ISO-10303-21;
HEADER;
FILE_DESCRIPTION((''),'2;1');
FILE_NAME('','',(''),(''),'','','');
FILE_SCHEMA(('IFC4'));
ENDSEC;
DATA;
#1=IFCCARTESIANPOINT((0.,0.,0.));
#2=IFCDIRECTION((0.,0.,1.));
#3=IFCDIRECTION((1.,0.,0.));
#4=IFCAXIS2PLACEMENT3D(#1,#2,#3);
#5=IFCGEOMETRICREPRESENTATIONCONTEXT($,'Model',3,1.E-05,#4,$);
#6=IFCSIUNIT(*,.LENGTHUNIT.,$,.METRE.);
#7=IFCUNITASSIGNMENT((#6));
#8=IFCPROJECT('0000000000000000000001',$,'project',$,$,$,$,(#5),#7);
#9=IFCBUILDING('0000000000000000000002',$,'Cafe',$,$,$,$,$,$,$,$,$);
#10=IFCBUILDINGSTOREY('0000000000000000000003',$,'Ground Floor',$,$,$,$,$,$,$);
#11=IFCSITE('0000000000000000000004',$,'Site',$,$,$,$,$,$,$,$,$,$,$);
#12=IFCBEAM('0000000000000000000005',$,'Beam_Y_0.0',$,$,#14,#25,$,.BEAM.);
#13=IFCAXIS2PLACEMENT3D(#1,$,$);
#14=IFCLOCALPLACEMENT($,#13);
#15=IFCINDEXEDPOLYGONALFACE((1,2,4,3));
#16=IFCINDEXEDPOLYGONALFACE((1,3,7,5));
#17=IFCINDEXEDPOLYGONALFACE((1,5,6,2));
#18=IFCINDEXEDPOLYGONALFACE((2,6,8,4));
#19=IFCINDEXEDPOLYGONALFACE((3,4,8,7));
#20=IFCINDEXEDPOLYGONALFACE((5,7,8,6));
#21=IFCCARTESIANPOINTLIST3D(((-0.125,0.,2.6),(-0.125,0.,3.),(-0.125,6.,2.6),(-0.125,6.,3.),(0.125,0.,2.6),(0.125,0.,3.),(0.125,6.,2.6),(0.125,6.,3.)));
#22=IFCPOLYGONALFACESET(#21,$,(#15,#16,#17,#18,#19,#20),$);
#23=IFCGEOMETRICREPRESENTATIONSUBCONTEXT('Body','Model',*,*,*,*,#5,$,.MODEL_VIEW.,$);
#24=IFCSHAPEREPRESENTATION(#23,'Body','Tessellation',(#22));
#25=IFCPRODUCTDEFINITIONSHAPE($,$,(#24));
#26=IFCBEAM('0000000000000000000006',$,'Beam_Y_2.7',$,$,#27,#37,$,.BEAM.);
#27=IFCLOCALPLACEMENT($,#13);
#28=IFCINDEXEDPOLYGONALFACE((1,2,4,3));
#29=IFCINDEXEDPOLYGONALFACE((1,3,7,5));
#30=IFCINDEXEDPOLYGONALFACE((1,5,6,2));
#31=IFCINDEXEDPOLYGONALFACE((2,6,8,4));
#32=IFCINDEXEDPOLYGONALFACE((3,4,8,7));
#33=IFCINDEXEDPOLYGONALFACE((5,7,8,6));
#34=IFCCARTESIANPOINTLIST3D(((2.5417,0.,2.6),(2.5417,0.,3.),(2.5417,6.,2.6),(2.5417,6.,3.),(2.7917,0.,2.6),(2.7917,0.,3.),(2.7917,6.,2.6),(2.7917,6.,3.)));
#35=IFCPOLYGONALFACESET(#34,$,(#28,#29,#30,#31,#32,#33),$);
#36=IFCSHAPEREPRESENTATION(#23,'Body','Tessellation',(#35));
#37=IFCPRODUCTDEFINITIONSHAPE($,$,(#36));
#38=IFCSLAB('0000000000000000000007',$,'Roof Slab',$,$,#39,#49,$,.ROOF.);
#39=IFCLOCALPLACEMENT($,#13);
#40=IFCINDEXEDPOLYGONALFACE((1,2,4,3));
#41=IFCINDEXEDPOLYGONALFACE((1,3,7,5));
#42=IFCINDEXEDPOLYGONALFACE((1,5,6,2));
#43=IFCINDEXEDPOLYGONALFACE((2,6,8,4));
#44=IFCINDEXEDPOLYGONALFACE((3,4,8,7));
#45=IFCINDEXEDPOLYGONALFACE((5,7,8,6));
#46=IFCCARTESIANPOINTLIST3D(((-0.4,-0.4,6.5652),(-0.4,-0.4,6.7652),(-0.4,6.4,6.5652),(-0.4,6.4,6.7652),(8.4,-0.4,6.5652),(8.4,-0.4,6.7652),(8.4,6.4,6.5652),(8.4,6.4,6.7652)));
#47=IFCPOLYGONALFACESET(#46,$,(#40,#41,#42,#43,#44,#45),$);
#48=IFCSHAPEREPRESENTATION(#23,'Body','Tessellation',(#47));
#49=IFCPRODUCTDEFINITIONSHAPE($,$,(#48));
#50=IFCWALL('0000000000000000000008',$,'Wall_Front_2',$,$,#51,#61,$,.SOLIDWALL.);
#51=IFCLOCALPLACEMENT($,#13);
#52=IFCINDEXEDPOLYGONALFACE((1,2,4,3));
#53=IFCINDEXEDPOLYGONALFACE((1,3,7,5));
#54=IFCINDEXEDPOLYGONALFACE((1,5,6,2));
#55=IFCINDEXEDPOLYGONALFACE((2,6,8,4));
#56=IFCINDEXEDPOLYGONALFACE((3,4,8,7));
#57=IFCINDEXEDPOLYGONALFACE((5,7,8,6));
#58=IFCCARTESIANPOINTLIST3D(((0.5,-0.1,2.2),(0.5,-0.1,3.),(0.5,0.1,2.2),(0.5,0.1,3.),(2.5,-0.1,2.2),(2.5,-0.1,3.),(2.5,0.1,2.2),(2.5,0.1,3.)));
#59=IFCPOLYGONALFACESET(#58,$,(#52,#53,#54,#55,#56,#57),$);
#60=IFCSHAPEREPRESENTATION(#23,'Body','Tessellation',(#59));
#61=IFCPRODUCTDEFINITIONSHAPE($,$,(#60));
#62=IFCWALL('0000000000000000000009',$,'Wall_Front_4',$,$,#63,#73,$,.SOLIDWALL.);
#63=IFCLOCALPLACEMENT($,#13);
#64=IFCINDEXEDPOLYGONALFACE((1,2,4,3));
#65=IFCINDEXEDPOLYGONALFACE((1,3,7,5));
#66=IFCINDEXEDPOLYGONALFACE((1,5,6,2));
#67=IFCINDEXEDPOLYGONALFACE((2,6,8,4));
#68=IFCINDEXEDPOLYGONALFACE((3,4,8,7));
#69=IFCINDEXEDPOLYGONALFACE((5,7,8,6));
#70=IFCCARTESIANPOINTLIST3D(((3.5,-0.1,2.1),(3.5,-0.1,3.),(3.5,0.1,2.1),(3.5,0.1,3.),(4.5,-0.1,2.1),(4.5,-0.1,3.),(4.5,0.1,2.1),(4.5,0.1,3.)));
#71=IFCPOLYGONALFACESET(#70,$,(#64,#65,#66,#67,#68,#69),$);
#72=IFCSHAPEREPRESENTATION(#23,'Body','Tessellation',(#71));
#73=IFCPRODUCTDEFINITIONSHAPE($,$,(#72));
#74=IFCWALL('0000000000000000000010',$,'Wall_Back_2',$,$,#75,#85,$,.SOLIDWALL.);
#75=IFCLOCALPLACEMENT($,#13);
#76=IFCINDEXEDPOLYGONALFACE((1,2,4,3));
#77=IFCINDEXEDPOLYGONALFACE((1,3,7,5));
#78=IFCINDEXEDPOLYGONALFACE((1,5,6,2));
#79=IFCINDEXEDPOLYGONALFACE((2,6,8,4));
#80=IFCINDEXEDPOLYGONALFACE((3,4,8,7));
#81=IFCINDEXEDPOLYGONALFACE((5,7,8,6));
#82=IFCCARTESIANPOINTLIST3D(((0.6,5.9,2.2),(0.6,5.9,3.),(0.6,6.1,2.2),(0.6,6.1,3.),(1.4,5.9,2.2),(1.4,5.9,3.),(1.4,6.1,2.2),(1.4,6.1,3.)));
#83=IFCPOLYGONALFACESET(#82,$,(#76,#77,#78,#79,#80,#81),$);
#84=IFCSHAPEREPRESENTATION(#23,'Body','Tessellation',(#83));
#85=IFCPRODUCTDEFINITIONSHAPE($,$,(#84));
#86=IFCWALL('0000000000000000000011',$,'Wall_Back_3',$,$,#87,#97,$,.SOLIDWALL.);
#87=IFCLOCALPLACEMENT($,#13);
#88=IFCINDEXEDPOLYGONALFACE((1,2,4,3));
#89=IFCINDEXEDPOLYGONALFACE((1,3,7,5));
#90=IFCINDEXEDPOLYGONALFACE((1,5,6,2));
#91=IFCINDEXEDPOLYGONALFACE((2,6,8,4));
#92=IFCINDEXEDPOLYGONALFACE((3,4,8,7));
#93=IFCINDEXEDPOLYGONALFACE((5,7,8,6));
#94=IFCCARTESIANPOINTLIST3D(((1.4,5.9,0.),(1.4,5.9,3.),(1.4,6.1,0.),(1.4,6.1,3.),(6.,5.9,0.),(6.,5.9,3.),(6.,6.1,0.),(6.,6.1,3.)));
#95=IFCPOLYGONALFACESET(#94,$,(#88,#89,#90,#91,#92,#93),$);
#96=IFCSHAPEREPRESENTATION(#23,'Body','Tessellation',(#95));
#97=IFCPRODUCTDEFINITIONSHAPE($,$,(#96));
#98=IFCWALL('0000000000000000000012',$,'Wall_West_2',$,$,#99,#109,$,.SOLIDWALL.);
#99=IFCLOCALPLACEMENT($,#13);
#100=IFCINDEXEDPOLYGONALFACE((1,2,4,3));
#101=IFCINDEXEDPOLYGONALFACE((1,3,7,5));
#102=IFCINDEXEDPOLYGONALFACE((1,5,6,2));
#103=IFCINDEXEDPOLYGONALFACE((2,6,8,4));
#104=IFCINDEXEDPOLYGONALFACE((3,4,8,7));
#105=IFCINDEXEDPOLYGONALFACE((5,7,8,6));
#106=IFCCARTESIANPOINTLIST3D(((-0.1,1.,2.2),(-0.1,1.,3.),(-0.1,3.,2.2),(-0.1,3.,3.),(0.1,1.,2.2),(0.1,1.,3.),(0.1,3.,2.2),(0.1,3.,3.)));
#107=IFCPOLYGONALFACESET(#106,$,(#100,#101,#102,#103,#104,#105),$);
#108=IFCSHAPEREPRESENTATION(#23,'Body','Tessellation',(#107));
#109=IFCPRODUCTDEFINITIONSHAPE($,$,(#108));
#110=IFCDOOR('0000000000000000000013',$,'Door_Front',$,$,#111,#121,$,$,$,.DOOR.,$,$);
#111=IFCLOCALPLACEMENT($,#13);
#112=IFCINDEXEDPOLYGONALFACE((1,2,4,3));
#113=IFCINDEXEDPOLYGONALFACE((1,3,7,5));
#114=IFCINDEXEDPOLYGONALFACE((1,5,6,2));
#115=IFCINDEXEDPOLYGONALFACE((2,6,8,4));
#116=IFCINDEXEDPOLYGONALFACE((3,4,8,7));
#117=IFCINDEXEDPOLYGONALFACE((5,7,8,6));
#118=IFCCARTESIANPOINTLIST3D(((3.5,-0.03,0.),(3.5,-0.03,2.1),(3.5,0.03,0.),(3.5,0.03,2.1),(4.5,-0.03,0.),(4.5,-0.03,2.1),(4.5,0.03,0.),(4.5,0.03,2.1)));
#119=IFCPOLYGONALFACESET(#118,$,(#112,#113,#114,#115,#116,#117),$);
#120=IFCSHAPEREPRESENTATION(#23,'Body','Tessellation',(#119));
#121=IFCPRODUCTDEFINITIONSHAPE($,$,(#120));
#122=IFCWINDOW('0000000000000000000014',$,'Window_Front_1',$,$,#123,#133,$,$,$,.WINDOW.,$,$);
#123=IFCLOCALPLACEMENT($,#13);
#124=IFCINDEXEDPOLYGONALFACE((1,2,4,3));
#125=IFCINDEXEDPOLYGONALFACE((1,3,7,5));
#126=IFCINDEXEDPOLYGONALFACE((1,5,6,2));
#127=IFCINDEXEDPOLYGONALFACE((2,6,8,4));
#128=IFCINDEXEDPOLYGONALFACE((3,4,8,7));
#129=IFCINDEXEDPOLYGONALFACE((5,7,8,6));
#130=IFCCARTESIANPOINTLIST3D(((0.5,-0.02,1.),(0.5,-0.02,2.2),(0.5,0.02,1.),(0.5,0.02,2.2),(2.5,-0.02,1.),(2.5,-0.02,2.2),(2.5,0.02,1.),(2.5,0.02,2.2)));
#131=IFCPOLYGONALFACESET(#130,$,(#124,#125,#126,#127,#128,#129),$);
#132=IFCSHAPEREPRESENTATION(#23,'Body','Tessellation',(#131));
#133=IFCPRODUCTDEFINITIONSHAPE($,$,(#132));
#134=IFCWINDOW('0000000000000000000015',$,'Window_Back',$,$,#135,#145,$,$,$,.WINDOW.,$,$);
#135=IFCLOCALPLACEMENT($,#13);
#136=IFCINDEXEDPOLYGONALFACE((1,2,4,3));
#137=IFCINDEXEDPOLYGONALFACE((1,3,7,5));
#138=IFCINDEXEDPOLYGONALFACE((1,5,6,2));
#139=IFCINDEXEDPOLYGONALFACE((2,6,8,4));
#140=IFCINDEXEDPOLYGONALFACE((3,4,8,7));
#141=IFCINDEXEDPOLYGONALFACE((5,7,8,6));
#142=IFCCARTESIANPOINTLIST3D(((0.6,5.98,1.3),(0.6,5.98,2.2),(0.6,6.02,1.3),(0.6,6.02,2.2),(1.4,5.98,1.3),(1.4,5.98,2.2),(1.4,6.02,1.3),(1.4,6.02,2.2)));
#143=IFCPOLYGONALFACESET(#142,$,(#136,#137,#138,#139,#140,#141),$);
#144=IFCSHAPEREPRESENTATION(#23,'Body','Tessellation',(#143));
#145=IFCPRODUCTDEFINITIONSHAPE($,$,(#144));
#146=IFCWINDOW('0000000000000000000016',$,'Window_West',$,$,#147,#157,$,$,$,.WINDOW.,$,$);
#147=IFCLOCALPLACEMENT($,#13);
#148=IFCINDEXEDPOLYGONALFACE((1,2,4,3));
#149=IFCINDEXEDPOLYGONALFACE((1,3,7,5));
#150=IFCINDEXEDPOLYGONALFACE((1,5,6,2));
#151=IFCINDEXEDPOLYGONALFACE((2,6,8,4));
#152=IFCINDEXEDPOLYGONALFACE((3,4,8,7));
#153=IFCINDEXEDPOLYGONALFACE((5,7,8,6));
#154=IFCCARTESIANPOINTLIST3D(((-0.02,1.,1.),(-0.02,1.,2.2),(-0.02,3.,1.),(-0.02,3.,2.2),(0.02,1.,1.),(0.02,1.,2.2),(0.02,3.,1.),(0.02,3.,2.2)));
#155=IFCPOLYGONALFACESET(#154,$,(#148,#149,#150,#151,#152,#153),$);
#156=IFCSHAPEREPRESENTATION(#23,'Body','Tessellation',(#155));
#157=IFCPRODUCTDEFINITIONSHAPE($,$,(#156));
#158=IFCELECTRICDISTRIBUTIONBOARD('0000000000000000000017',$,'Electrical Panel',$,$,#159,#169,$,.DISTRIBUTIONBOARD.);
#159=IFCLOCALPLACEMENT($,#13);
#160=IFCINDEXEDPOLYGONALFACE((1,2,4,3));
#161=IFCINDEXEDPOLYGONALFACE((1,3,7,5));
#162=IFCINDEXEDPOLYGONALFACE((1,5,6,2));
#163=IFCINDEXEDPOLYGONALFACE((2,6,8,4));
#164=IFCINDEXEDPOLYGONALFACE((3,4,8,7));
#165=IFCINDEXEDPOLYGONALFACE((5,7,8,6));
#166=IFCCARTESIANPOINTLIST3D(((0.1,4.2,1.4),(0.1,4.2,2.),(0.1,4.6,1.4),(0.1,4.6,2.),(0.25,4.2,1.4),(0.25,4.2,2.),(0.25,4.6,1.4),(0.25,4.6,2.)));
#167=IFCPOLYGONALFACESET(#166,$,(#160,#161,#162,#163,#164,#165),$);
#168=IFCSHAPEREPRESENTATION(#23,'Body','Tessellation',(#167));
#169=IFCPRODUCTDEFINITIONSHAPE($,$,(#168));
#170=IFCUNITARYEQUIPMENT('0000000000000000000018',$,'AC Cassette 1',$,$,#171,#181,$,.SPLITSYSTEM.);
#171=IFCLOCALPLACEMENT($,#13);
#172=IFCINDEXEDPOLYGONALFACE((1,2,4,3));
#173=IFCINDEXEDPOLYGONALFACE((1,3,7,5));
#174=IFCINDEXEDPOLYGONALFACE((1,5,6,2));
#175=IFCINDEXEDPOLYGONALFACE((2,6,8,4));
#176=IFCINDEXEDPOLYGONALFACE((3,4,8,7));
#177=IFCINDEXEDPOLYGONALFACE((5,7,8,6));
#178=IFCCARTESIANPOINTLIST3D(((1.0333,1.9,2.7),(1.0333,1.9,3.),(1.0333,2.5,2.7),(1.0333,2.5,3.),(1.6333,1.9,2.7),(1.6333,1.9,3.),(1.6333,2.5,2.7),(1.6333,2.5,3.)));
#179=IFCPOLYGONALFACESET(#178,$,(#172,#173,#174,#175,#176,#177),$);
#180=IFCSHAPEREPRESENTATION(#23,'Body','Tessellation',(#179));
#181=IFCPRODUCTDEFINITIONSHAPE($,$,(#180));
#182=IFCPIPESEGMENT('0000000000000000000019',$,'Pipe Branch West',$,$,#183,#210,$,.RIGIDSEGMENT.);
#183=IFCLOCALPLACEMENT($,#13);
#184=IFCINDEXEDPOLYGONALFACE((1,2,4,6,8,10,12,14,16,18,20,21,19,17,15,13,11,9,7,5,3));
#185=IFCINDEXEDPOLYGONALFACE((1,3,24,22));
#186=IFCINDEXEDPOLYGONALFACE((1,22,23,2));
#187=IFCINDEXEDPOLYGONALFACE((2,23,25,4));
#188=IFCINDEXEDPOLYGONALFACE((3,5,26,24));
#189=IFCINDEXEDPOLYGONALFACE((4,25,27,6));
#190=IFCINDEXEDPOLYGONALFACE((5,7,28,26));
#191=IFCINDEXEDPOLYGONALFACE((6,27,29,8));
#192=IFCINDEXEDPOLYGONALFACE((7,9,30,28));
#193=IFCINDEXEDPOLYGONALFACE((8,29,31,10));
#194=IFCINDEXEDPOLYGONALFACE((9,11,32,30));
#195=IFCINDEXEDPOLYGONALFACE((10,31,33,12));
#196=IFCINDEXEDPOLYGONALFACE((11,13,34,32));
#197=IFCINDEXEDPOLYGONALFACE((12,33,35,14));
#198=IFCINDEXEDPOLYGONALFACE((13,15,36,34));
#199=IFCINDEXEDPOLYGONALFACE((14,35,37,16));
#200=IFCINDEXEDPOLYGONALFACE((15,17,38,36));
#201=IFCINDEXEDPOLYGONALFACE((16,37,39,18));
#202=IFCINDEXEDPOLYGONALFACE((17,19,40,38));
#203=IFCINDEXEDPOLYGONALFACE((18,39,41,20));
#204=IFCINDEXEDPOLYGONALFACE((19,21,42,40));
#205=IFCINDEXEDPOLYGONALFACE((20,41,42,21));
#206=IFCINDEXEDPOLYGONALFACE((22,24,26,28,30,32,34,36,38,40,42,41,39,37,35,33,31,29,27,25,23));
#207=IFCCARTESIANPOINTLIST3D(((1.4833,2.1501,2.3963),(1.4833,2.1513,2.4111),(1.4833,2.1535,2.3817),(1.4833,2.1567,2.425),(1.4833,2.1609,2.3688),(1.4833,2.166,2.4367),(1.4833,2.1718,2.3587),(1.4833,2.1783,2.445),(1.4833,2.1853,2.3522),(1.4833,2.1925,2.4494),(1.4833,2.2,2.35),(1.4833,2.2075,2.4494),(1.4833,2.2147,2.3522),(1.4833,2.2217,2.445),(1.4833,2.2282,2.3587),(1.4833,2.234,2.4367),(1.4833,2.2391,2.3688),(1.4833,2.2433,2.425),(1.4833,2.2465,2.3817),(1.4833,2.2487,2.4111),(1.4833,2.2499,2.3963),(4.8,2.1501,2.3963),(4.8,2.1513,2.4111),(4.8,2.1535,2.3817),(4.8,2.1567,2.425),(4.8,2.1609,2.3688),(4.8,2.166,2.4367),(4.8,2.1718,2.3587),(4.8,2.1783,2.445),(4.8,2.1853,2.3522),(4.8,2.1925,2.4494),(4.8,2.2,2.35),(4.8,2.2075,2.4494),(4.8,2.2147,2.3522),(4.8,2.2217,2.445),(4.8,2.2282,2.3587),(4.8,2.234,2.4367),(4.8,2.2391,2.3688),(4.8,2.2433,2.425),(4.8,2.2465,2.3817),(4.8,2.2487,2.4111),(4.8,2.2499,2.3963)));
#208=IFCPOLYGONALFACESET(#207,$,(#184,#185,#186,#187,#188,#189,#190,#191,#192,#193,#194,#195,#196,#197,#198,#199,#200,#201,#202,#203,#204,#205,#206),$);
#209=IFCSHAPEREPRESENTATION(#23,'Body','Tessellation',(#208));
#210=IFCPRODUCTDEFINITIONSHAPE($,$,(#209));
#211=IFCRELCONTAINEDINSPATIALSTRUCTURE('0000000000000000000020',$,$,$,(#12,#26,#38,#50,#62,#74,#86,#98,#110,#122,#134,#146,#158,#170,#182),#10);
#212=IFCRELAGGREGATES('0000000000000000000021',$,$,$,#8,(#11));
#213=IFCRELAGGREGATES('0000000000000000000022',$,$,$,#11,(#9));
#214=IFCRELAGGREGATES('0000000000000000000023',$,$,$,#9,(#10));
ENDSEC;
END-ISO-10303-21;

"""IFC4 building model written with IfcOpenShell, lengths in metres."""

from ifc_helpers import new_model, si_unit, frame, origin, origin_with_axes, origin_2d, place, context, subcontext, project, spatial, rectangle, circle, extrude, element, save


model = new_model("IFC4")

# Units and contexts
model_context = context("Model", 3, precision=1e-05, world=origin_with_axes())
body_context = subcontext(model_context, "Body", "Model", "MODEL_VIEW")
ifc_project = project(units=[si_unit("LENGTHUNIT", "METRE")], contexts=[model_context])

# Site, building, storey
site = spatial("IfcSite", under=ifc_project, Name="Site")
building = spatial("IfcBuilding", under=site, Name="Cafe")
storey = spatial("IfcBuildingStorey", under=building, Name="Ground Floor")

# Beams
for number, where, z_axis, x_axis, name in (
    (1, (0.0, 3.0, 2.6), (0.0, 0.0, 1.0), (1.0, 0.0, 0.0), "Beam_Y_0.0"),
    (2, (2.6667, 3.0, 2.6), (0.0, 0.0, 1.0), (1.0, 0.0, 0.0), "Beam_Y_2.7"),
):
    element("IfcBeam", number, at=place(None, frame(where, z_axis=z_axis, x_axis=x_axis)), inside=storey, Name=name, PredefinedType="BEAM", context=body_context, shape_type="SweptSolid", body=[
        extrude(rectangle(XDim=0.25, YDim=6.0, at=origin_2d()), origin(), (0.0, 0.0, 1.0), 0.4),
    ])

# Slab
slab_placement = place(None, frame((4.0, 3.0, 6.5652), z_axis=(0.0, 0.0, 1.0), x_axis=(1.0, 0.0, 0.0)))
element("IfcSlab", 3, at=slab_placement, inside=storey, Name="Roof Slab", PredefinedType="ROOF", context=body_context, shape_type="SweptSolid", body=[
    extrude(rectangle(XDim=8.8, YDim=6.8, at=origin_2d()), origin(), (0.0, 0.0, 1.0), 0.2),
])

# Walls
wall_1_placement = place(None, frame((1.5, 0.0, 2.2), z_axis=(0.0, 0.0, 1.0), x_axis=(1.0, 0.0, 0.0)))
element("IfcWall", 4, at=wall_1_placement, inside=storey, Name="Wall_Front_2", PredefinedType="SOLIDWALL", context=body_context, shape_type="SweptSolid", body=[
    extrude(rectangle(XDim=2.0, YDim=0.2, at=origin_2d()), origin(), (0.0, 0.0, 1.0), 0.8),
])
wall_2_placement = place(None, frame((4.0, 0.0, 2.1), z_axis=(0.0, 0.0, 1.0), x_axis=(1.0, 0.0, 0.0)))
element("IfcWall", 5, at=wall_2_placement, inside=storey, Name="Wall_Front_4", PredefinedType="SOLIDWALL", context=body_context, shape_type="SweptSolid", body=[
    extrude(rectangle(XDim=1.0, YDim=0.2, at=origin_2d()), origin(), (0.0, 0.0, 1.0), 0.9),
])
wall_3_placement = place(None, frame((1.0, 6.0, 2.2), z_axis=(0.0, 0.0, 1.0), x_axis=(1.0, 0.0, 0.0)))
element("IfcWall", 6, at=wall_3_placement, inside=storey, Name="Wall_Back_2", PredefinedType="SOLIDWALL", context=body_context, shape_type="SweptSolid", body=[
    extrude(rectangle(XDim=0.8, YDim=0.2, at=origin_2d()), origin(), (0.0, 0.0, 1.0), 0.8),
])
wall_4_placement = place(None, frame((3.7, 6.0, 0.0), z_axis=(0.0, 0.0, 1.0), x_axis=(1.0, 0.0, 0.0)))
element("IfcWall", 7, at=wall_4_placement, inside=storey, Name="Wall_Back_3", PredefinedType="SOLIDWALL", context=body_context, shape_type="SweptSolid", body=[
    extrude(rectangle(XDim=4.6, YDim=0.2, at=origin_2d()), origin(), (0.0, 0.0, 1.0), 3.0),
])
wall_5_placement = place(None, frame((0.0, 2.0, 2.2), z_axis=(0.0, 0.0, 1.0), x_axis=(1.0, 0.0, 0.0)))
element("IfcWall", 8, at=wall_5_placement, inside=storey, Name="Wall_West_2", PredefinedType="SOLIDWALL", context=body_context, shape_type="SweptSolid", body=[
    extrude(rectangle(XDim=0.2, YDim=2.0, at=origin_2d()), origin(), (0.0, 0.0, 1.0), 0.8),
])

# Door
door_placement = place(None, frame((4.0, 0.0, 0.0), z_axis=(0.0, 0.0, 1.0), x_axis=(1.0, 0.0, 0.0)))
element("IfcDoor", 9, at=door_placement, inside=storey, Name="Door_Front", PredefinedType="DOOR", context=body_context, shape_type="SweptSolid", body=[
    extrude(rectangle(XDim=1.0, YDim=0.06, at=origin_2d()), origin(), (0.0, 0.0, 1.0), 2.1),
])

# Windows
window_1_placement = place(None, frame((1.5, 0.0, 1.0), z_axis=(0.0, 0.0, 1.0), x_axis=(1.0, 0.0, 0.0)))
element("IfcWindow", 10, at=window_1_placement, inside=storey, Name="Window_Front_1", PredefinedType="WINDOW", context=body_context, shape_type="SweptSolid", body=[
    extrude(rectangle(XDim=2.0, YDim=0.04, at=origin_2d()), origin(), (0.0, 0.0, 1.0), 1.2),
])
window_2_placement = place(None, frame((1.0, 6.0, 1.3), z_axis=(0.0, 0.0, 1.0), x_axis=(1.0, 0.0, 0.0)))
element("IfcWindow", 11, at=window_2_placement, inside=storey, Name="Window_Back", PredefinedType="WINDOW", context=body_context, shape_type="SweptSolid", body=[
    extrude(rectangle(XDim=0.8, YDim=0.04, at=origin_2d()), origin(), (0.0, 0.0, 1.0), 0.9),
])
window_3_placement = place(None, frame((0.0, 2.0, 1.0), z_axis=(0.0, 0.0, 1.0), x_axis=(1.0, 0.0, 0.0)))
element("IfcWindow", 12, at=window_3_placement, inside=storey, Name="Window_West", PredefinedType="WINDOW", context=body_context, shape_type="SweptSolid", body=[
    extrude(rectangle(XDim=0.04, YDim=2.0, at=origin_2d()), origin(), (0.0, 0.0, 1.0), 1.2),
])

# Electric distribution board
electric_distribution_board_placement = place(None, frame((0.175, 4.4, 1.4), z_axis=(0.0, 0.0, 1.0), x_axis=(1.0, 0.0, 0.0)))
element("IfcElectricDistributionBoard", 13, at=electric_distribution_board_placement, inside=storey, Name="Electrical Panel", PredefinedType="DISTRIBUTIONBOARD", context=body_context, shape_type="SweptSolid", body=[
    extrude(rectangle(XDim=0.15, YDim=0.4, at=origin_2d()), origin(), (0.0, 0.0, 1.0), 0.6),
])

# Unitary equipment
unitary_equipment_placement = place(None, frame((1.3333, 2.2, 2.7), z_axis=(0.0, 0.0, 1.0), x_axis=(1.0, 0.0, 0.0)))
element("IfcUnitaryEquipment", 14, at=unitary_equipment_placement, inside=storey, Name="AC Cassette 1", PredefinedType="SPLITSYSTEM", context=body_context, shape_type="SweptSolid", body=[
    extrude(rectangle(XDim=0.6, YDim=0.6, at=origin_2d()), origin(), (0.0, 0.0, 1.0), 0.3),
])

# Pipe segment
pipe_segment_1_placement = place(None, frame((1.4833, 2.2, 2.4), z_axis=(1.0, 0.0, 0.0), x_axis=(0.0, 0.0, -1.0)))
element("IfcPipeSegment", 15, at=pipe_segment_1_placement, inside=storey, Name="Pipe Branch West", PredefinedType="RIGIDSEGMENT", context=body_context, shape_type="SweptSolid", body=[
    extrude(circle(Radius=0.05, at=origin_2d()), origin(), (0.0, 0.0, 1.0), 3.3167),
])

save(model, "model.ifc")
